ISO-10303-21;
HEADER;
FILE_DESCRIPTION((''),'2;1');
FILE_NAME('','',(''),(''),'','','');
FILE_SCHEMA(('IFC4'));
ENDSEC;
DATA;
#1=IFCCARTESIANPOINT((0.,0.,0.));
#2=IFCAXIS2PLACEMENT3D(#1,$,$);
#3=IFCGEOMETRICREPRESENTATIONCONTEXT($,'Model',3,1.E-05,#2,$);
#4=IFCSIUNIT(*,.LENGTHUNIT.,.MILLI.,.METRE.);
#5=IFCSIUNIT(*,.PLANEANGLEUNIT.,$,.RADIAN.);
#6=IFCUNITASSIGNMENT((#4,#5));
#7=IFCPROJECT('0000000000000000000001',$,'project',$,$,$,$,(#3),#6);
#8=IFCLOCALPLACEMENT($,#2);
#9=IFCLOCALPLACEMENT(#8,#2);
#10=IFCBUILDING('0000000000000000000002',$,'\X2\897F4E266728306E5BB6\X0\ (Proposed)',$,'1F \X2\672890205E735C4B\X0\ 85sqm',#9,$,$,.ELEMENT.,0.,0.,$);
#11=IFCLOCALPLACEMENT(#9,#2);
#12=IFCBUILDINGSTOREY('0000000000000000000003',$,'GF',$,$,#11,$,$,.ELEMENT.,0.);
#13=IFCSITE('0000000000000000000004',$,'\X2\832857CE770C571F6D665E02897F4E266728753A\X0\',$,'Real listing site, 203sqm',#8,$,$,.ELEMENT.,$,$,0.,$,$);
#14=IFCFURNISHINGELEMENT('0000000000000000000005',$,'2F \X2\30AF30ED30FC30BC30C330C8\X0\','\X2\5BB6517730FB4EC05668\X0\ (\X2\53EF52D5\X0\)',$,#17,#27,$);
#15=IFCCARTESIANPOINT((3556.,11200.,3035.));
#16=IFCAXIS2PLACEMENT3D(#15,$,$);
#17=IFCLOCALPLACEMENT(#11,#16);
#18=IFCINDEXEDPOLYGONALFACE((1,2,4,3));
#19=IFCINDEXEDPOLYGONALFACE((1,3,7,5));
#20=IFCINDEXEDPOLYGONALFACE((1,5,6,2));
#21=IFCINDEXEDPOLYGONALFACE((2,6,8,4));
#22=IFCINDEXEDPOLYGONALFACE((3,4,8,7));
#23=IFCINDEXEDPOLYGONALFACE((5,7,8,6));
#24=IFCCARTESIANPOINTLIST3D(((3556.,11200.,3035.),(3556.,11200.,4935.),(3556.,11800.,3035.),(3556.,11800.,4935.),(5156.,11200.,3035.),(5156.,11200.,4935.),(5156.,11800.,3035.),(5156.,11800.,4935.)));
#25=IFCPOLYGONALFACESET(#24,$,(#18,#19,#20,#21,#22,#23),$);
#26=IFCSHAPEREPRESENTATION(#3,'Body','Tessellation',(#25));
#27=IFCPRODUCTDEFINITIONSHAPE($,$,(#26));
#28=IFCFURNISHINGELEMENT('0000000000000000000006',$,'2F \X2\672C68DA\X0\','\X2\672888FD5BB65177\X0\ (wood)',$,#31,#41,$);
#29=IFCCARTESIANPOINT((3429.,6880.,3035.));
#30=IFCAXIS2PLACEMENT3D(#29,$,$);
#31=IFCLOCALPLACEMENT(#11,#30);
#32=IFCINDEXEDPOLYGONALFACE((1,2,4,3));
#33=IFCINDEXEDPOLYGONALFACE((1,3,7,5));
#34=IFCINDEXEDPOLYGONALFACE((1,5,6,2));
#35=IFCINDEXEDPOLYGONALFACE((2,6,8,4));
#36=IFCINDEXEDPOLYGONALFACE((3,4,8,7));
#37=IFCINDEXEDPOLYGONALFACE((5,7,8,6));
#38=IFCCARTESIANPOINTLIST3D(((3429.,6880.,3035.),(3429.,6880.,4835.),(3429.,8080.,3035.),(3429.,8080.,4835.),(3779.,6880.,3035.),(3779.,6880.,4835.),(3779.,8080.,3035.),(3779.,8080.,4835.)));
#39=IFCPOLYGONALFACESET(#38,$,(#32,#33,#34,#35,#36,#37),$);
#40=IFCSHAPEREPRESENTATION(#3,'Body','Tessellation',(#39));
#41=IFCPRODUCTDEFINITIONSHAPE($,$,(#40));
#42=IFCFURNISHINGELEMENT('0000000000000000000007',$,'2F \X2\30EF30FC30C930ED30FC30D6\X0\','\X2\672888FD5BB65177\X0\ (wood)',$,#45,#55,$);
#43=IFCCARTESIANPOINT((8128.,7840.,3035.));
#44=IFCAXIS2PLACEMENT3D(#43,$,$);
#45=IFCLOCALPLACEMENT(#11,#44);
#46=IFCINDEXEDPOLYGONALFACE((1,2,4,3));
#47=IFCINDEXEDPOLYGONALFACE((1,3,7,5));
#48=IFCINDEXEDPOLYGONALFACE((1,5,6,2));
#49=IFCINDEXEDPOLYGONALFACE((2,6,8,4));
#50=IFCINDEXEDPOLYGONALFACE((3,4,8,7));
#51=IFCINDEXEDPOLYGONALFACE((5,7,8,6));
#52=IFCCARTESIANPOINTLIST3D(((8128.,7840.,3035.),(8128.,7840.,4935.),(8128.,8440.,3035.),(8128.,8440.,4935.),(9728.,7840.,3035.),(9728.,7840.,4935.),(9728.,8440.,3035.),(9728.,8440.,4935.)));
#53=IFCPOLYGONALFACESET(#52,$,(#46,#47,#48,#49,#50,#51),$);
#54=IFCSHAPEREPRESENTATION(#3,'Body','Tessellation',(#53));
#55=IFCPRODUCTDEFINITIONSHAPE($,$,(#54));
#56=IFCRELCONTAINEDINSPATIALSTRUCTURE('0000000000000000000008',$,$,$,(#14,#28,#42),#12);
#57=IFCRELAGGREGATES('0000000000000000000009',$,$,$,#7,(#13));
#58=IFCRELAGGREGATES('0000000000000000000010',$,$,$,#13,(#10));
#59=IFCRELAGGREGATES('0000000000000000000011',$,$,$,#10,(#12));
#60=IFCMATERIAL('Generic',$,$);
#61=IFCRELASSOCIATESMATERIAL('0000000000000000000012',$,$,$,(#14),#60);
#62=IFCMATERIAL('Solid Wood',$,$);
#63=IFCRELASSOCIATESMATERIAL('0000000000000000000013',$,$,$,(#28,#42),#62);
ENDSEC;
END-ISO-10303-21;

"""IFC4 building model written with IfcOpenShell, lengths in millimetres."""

from ifc_helpers import new_model, si_unit, frame, frame_2d, origin, place, context, project, spatial, rectangle, extrude, material, element, save


model = new_model("IFC4")

# Units and contexts
model_context = context("Model", 3, precision=1e-05, world=origin())
ifc_project = project(units=[si_unit("LENGTHUNIT", "METRE", prefix="MILLI"), si_unit("PLANEANGLEUNIT", "RADIAN")], contexts=[model_context])

# Site, building, storey
site_placement = place(None, origin())
site = spatial("IfcSite", under=ifc_project, at=site_placement, Name="茨城県土浦市西並木町", ObjectType="Real listing site, 203sqm", CompositionType="ELEMENT", RefElevation=0.0)
building_placement = place(site_placement, origin())
building = spatial("IfcBuilding", under=site, at=building_placement, Name="西並木の家 (Proposed)", ObjectType="1F 木造平屋 85sqm", CompositionType="ELEMENT", ElevationOfRefHeight=0.0, ElevationOfTerrain=0.0)
storey_placement = place(building_placement, origin())
storey = spatial("IfcBuildingStorey", under=building, at=storey_placement, Name="GF", CompositionType="ELEMENT", Elevation=0.0)

# Shared definitions
ifc_material_1 = material(Name="Solid Wood")

# Shared definitions
ifc_material_2 = material(Name="Generic")

# Furnishing elements
furnishing_1_placement = place(storey_placement, frame((3556.0, 11200.0, 3035.0)))
element("IfcFurnishingElement", 1, at=furnishing_1_placement, inside=storey, material=ifc_material_2, Name="2F クローゼット", Description="家具・什器 (可動)", context=model_context, shape_type="SweptSolid", body=[
    extrude(rectangle(XDim=1600.0, YDim=600.0, at=frame_2d((800.0, 300.0))), frame((3556.0, 11200.0, 3035.0)), (0.0, 0.0, 1.0), 1900.0),
])
furnishing_2_placement = place(storey_placement, frame((3429.0, 6880.0, 3035.0)))
element("IfcFurnishingElement", 2, at=furnishing_2_placement, inside=storey, material=ifc_material_1, Name="2F 本棚", Description="木製家具 (wood)", context=model_context, shape_type="SweptSolid", body=[
    extrude(rectangle(XDim=350.0, YDim=1200.0, at=frame_2d((175.0, 600.0))), frame((3429.0, 6880.0, 3035.0)), (0.0, 0.0, 1.0), 1800.0),
])
furnishing_3_placement = place(storey_placement, frame((8128.0, 7840.0, 3035.0)))
element("IfcFurnishingElement", 3, at=furnishing_3_placement, inside=storey, material=ifc_material_1, Name="2F ワードローブ", Description="木製家具 (wood)", context=model_context, shape_type="SweptSolid", body=[
    extrude(rectangle(XDim=1600.0, YDim=600.0, at=frame_2d((800.0, 300.0))), frame((8128.0, 7840.0, 3035.0)), (0.0, 0.0, 1.0), 1900.0),
])

save(model, "model.ifc")
